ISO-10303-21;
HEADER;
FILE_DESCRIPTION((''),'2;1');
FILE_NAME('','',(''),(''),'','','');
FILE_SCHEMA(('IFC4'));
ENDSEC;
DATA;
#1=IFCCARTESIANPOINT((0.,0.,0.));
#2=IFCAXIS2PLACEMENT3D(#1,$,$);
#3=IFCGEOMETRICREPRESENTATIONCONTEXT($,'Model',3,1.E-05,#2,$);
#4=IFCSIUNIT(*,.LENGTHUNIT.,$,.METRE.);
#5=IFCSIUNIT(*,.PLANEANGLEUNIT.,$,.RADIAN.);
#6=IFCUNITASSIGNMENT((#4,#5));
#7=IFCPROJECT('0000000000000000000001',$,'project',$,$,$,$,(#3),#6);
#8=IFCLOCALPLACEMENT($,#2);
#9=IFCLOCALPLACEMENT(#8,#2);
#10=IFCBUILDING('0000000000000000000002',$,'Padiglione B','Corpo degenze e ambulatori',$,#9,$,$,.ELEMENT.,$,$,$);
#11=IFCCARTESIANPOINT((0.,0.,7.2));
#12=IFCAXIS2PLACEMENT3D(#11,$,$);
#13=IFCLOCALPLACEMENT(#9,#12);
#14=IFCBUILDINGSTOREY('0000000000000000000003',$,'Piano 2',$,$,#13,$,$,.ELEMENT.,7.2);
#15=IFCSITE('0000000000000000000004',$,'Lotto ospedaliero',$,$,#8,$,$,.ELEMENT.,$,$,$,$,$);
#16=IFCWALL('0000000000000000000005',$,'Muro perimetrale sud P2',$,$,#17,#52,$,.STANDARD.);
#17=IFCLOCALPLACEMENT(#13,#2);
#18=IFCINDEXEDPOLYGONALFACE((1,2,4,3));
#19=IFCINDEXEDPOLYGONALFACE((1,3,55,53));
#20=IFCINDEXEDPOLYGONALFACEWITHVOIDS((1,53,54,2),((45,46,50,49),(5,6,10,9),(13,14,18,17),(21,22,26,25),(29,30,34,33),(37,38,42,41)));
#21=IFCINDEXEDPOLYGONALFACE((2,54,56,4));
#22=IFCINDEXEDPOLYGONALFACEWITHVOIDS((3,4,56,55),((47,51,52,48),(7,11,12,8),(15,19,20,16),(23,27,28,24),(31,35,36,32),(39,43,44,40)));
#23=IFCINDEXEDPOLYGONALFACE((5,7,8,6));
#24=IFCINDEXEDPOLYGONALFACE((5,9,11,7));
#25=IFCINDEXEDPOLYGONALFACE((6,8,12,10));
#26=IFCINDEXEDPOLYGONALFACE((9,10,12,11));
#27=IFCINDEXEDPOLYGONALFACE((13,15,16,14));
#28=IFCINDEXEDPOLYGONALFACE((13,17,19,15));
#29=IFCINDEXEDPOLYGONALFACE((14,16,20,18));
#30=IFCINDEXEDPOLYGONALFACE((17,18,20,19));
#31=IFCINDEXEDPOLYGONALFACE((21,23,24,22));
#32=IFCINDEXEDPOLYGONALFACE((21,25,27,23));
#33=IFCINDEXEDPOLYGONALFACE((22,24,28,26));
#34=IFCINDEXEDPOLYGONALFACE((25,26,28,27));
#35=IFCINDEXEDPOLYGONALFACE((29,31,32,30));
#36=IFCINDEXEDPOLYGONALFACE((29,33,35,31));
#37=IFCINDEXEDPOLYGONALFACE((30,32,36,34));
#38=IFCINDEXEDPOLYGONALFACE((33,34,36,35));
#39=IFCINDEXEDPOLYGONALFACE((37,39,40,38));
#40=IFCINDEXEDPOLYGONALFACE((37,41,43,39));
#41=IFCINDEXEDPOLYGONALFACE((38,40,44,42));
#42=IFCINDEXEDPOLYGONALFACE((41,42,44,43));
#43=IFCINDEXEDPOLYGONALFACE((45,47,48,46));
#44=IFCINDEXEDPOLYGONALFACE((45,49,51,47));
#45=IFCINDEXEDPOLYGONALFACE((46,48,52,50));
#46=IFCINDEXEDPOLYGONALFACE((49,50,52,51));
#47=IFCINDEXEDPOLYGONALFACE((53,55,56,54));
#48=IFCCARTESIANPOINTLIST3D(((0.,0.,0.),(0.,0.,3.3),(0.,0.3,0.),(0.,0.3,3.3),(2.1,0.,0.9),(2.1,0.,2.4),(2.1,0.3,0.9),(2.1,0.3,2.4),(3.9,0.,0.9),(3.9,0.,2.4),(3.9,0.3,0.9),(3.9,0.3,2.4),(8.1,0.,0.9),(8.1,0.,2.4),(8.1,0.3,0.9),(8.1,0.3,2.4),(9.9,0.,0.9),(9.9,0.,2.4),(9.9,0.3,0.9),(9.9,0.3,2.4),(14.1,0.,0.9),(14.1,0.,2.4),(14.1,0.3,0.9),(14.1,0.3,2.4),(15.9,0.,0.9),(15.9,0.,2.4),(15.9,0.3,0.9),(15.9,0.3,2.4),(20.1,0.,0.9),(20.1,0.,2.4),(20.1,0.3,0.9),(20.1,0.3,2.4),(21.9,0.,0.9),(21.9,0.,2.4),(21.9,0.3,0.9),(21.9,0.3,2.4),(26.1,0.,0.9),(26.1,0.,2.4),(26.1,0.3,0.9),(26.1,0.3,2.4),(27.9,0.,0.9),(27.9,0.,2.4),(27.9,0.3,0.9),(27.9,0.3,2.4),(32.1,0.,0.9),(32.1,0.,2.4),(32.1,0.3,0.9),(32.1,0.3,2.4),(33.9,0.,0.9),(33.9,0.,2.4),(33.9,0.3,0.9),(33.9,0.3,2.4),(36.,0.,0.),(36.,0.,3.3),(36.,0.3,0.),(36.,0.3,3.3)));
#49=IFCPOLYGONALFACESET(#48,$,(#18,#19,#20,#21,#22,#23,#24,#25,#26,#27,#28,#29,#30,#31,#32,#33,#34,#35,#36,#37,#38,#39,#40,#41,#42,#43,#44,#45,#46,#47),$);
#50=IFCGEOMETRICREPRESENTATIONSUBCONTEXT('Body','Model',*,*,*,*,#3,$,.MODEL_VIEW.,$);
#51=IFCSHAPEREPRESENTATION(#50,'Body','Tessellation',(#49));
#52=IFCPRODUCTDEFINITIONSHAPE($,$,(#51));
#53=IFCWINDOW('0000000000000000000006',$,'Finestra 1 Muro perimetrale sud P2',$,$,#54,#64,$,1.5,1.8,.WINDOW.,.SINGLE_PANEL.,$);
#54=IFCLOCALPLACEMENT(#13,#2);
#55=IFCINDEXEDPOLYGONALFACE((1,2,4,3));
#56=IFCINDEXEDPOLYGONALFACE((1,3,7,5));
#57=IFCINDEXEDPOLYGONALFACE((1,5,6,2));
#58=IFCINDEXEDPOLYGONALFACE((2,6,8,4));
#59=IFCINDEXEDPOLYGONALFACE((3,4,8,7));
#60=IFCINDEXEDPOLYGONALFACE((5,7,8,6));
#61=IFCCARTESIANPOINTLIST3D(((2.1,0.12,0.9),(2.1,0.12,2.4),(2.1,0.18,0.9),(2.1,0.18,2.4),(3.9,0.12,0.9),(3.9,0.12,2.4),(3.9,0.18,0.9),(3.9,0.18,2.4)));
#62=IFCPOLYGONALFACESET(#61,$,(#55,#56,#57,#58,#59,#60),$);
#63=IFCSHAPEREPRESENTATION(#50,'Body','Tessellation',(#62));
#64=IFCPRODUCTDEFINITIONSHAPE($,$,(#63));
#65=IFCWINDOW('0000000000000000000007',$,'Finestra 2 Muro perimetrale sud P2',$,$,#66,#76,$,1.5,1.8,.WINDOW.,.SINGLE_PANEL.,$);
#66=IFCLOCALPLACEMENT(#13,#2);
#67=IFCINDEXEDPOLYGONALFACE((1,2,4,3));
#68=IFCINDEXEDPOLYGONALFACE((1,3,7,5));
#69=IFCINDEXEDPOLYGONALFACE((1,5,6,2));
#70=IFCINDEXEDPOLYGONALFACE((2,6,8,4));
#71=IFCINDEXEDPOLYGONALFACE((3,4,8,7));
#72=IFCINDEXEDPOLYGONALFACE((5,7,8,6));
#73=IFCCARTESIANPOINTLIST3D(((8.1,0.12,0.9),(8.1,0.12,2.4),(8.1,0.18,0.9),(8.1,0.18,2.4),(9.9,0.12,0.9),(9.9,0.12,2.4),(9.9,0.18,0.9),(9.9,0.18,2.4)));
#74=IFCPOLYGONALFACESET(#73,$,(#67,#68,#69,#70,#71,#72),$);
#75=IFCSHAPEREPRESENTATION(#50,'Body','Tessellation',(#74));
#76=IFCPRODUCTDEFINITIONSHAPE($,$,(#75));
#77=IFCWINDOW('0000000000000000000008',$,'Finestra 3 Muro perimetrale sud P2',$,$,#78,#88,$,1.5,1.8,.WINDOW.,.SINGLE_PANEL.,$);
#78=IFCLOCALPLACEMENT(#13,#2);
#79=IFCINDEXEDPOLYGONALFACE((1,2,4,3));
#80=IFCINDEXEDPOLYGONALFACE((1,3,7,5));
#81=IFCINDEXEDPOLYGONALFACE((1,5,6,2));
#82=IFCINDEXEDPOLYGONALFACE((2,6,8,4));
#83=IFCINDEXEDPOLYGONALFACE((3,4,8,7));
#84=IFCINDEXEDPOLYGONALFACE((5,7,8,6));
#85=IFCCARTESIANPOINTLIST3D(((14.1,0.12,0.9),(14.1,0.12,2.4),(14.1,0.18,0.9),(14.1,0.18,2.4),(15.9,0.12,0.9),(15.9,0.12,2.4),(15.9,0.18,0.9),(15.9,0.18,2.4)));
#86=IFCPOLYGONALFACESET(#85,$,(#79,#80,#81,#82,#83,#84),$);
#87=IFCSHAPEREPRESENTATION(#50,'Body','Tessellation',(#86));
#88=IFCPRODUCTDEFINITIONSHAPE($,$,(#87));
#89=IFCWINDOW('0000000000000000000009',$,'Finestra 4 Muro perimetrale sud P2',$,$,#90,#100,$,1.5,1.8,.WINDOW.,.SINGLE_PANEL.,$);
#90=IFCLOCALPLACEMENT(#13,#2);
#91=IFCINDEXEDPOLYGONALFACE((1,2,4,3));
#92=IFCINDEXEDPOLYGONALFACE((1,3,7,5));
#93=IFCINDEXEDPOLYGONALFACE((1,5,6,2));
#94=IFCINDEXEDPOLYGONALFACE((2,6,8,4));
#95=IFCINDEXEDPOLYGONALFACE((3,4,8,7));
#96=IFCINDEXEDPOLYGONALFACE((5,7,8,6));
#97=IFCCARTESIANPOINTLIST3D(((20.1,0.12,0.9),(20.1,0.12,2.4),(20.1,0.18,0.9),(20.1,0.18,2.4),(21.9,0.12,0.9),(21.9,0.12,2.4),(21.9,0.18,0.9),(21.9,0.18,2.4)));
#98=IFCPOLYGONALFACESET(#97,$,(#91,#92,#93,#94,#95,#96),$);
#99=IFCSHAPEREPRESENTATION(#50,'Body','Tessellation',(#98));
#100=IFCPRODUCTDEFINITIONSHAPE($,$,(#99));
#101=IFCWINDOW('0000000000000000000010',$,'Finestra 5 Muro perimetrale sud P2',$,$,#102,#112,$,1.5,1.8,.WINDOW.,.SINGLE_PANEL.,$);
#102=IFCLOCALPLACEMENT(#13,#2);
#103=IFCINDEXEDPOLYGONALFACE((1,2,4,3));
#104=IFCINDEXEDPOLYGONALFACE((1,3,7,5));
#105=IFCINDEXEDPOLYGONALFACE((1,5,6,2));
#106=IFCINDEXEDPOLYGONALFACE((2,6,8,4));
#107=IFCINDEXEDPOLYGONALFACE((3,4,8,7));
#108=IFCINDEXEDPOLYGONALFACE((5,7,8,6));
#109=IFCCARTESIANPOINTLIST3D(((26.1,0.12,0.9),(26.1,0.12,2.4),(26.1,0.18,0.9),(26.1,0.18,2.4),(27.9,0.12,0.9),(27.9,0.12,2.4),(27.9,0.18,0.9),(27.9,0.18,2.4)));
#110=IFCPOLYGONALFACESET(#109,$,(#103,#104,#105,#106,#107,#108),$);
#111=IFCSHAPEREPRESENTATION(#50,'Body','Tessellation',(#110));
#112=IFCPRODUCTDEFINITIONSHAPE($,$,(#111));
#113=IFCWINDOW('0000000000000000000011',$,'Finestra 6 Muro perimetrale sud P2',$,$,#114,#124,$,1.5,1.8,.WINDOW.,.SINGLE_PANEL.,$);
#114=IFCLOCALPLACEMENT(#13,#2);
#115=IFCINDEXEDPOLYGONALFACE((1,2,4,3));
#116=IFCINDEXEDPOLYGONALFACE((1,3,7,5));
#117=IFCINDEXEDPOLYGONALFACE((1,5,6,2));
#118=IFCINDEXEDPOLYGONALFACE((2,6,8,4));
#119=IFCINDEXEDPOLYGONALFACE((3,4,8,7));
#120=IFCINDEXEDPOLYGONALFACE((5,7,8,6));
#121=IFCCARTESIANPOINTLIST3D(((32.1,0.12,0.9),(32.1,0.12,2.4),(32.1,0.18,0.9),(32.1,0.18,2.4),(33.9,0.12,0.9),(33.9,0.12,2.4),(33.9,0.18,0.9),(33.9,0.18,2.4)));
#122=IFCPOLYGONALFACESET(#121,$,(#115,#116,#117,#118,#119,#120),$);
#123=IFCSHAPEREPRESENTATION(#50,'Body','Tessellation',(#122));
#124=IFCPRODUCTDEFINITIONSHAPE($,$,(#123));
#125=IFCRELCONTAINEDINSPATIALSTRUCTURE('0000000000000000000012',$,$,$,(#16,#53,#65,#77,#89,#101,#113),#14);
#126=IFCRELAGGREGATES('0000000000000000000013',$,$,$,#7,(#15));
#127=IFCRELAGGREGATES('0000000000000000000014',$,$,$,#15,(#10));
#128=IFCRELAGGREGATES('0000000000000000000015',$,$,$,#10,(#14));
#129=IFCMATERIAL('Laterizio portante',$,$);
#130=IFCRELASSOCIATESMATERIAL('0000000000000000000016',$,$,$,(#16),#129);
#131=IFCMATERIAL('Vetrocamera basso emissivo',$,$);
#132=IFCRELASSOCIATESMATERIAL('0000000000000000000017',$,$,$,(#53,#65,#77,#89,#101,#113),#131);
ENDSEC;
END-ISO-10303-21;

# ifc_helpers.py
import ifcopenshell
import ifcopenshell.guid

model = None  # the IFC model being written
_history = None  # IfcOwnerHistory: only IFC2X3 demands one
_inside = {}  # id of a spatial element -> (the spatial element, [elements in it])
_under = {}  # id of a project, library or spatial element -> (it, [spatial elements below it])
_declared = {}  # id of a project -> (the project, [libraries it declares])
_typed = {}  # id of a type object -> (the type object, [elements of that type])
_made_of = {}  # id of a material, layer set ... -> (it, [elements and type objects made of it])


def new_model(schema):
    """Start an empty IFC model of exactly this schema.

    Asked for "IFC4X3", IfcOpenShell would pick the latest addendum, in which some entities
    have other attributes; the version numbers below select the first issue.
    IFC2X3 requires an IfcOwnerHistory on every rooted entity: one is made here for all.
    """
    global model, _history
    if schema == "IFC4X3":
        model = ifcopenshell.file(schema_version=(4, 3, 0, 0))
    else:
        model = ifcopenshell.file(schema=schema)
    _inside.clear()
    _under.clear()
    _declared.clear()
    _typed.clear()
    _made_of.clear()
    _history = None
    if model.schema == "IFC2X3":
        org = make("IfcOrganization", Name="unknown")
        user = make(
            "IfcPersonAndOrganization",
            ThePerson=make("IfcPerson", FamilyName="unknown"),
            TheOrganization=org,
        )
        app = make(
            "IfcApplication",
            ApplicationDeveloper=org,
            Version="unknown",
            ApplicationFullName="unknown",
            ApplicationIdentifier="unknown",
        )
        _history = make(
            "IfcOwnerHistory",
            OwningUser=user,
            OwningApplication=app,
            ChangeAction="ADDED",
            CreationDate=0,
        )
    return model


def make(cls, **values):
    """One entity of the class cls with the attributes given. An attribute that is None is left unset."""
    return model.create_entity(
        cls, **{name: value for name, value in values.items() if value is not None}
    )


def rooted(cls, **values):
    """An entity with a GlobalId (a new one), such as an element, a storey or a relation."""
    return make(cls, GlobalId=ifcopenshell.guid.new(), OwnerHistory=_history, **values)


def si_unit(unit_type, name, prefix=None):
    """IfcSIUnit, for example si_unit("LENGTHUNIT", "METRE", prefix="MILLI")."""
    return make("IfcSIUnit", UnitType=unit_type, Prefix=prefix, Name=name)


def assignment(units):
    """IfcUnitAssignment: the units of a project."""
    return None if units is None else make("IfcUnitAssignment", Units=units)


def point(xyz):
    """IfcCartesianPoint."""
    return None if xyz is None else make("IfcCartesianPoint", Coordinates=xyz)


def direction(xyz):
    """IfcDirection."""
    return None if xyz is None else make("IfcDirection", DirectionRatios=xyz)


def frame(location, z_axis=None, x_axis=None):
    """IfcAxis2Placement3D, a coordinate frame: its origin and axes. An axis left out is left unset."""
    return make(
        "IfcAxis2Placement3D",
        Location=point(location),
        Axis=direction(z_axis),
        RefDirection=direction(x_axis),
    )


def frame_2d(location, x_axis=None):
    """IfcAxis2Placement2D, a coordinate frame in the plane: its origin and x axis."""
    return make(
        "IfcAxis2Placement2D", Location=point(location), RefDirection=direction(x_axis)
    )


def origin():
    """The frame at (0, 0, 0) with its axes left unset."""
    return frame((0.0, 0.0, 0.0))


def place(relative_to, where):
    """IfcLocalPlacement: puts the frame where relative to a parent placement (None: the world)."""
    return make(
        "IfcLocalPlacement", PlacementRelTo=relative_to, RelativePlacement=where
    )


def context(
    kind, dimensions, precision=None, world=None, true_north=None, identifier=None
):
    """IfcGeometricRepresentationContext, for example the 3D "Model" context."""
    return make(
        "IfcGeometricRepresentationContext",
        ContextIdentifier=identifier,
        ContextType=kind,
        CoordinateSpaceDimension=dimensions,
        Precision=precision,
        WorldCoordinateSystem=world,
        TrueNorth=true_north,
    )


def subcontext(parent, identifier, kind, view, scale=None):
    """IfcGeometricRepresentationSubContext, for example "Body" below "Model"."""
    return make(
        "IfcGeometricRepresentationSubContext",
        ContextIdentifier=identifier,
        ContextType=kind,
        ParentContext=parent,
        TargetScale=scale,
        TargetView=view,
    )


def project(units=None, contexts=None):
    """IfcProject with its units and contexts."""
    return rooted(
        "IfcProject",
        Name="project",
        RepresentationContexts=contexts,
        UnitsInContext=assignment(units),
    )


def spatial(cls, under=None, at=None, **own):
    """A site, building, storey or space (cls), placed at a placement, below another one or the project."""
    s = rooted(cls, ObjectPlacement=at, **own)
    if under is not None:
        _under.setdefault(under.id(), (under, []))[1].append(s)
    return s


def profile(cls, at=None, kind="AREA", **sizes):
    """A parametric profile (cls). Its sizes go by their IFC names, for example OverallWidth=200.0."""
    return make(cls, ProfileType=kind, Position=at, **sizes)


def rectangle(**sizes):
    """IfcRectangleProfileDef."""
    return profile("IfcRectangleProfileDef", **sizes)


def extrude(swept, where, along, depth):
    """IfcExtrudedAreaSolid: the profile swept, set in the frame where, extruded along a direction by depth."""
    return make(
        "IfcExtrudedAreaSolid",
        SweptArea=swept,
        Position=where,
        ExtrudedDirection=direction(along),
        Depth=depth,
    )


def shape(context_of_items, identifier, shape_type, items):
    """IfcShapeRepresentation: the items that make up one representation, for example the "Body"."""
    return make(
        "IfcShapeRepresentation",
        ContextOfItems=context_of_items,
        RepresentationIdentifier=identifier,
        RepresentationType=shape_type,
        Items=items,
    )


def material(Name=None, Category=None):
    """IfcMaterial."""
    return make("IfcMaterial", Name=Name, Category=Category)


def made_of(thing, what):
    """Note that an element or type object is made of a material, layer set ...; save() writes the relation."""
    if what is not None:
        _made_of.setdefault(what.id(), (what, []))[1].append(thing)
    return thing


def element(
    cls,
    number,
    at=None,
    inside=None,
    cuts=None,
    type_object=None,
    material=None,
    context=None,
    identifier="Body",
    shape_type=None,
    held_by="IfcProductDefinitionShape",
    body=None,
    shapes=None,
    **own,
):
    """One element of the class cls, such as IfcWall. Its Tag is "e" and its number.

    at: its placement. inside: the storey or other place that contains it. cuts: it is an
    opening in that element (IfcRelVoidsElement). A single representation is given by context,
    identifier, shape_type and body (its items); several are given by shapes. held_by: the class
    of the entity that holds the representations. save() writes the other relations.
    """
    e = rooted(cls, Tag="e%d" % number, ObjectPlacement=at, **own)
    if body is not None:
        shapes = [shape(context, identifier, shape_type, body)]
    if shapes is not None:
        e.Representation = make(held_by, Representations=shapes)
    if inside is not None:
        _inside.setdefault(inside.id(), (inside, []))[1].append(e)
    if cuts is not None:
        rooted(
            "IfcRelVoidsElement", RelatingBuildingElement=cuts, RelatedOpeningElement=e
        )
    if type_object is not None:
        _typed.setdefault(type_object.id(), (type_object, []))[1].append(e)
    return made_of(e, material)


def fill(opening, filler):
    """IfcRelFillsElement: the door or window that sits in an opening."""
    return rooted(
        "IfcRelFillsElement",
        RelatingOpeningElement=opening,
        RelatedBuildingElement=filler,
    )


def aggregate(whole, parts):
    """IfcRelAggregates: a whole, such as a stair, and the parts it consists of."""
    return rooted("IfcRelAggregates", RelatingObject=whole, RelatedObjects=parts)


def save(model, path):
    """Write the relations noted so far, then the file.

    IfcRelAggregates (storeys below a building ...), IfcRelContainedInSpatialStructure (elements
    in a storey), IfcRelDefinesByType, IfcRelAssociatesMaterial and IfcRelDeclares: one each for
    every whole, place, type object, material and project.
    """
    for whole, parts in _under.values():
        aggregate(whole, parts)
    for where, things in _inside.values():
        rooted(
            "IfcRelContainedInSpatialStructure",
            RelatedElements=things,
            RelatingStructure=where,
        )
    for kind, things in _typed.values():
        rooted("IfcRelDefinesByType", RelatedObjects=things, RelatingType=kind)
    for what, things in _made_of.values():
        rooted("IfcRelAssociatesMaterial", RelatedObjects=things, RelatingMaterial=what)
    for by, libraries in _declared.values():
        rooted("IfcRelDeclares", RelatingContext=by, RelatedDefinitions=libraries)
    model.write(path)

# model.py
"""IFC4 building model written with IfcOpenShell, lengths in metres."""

from ifc_helpers import new_model, si_unit, frame, frame_2d, origin, place, context, subcontext, project, spatial, rectangle, extrude, material, element, fill, save


model = new_model("IFC4")

# Units and contexts
model_context = context("Model", 3, precision=1e-05, world=origin())
body_context = subcontext(model_context, "Body", "Model", "MODEL_VIEW")
ifc_project = project(units=[si_unit("LENGTHUNIT", "METRE"), si_unit("PLANEANGLEUNIT", "RADIAN")], contexts=[model_context])

# Site, building, storey
site_placement = place(None, origin())
site = spatial("IfcSite", under=ifc_project, at=site_placement, Name="Lotto ospedaliero", CompositionType="ELEMENT")
building_placement = place(site_placement, origin())
building = spatial("IfcBuilding", under=site, at=building_placement, Name="Padiglione B", Description="Corpo degenze e ambulatori", CompositionType="ELEMENT")
storey_placement = place(building_placement, frame((0.0, 0.0, 7.2)))
storey = spatial("IfcBuildingStorey", under=building, at=storey_placement, Name="Piano 2", CompositionType="ELEMENT", Elevation=7.2)

# Wall, openings, windows
ifc_material_1 = material(Name="Laterizio portante")
wall_1_placement = place(storey_placement, origin())
wall_1 = element("IfcWall", 1, at=wall_1_placement, inside=storey, material=ifc_material_1, Name="Muro perimetrale sud P2", PredefinedType="STANDARD", context=body_context, shape_type="SweptSolid", body=[
    extrude(rectangle(XDim=36.0, YDim=0.3, at=frame_2d((18.0, 0.15))), origin(), (0.0, 0.0, 1.0), 3.3),
])
opening_1_placement = place(wall_1_placement, frame((2.1, -0.1, 0.9)))
opening_1 = element("IfcOpeningElement", 2, at=opening_1_placement, cuts=wall_1, PredefinedType="OPENING", context=body_context, shape_type="SweptSolid", body=[
    extrude(rectangle(XDim=1.8, YDim=0.5, at=frame_2d((0.9, 0.25))), origin(), (0.0, 0.0, 1.0), 1.5),
])
opening_2_placement = place(wall_1_placement, frame((8.1, -0.1, 0.9)))
opening_2 = element("IfcOpeningElement", 3, at=opening_2_placement, cuts=wall_1, PredefinedType="OPENING", context=body_context, shape_type="SweptSolid", body=[
    extrude(rectangle(XDim=1.8, YDim=0.5, at=frame_2d((0.9, 0.25))), origin(), (0.0, 0.0, 1.0), 1.5),
])
opening_3_placement = place(wall_1_placement, frame((14.1, -0.1, 0.9)))
opening_3 = element("IfcOpeningElement", 4, at=opening_3_placement, cuts=wall_1, PredefinedType="OPENING", context=body_context, shape_type="SweptSolid", body=[
    extrude(rectangle(XDim=1.8, YDim=0.5, at=frame_2d((0.9, 0.25))), origin(), (0.0, 0.0, 1.0), 1.5),
])
opening_4_placement = place(wall_1_placement, frame((20.1, -0.1, 0.9)))
opening_4 = element("IfcOpeningElement", 5, at=opening_4_placement, cuts=wall_1, PredefinedType="OPENING", context=body_context, shape_type="SweptSolid", body=[
    extrude(rectangle(XDim=1.8, YDim=0.5, at=frame_2d((0.9, 0.25))), origin(), (0.0, 0.0, 1.0), 1.5),
])
opening_5_placement = place(wall_1_placement, frame((26.1, -0.1, 0.9)))
opening_5 = element("IfcOpeningElement", 6, at=opening_5_placement, cuts=wall_1, PredefinedType="OPENING", context=body_context, shape_type="SweptSolid", body=[
    extrude(rectangle(XDim=1.8, YDim=0.5, at=frame_2d((0.9, 0.25))), origin(), (0.0, 0.0, 1.0), 1.5),
])
opening_6_placement = place(wall_1_placement, frame((32.1, -0.1, 0.9)))
opening_6 = element("IfcOpeningElement", 7, at=opening_6_placement, cuts=wall_1, PredefinedType="OPENING", context=body_context, shape_type="SweptSolid", body=[
    extrude(rectangle(XDim=1.8, YDim=0.5, at=frame_2d((0.9, 0.25))), origin(), (0.0, 0.0, 1.0), 1.5),
])
ifc_material_2 = material(Name="Vetrocamera basso emissivo")
window_1_placement = place(wall_1_placement, frame((2.1, 0.12, 0.9)))
window_1 = element("IfcWindow", 8, at=window_1_placement, inside=storey, material=ifc_material_2, Name="Finestra 1 Muro perimetrale sud P2", OverallHeight=1.5, OverallWidth=1.8, PartitioningType="SINGLE_PANEL", PredefinedType="WINDOW", context=body_context, shape_type="SweptSolid", body=[
    extrude(rectangle(XDim=1.8, YDim=0.06, at=frame_2d((0.9, 0.03))), origin(), (0.0, 0.0, 1.0), 1.5),
])
fill(opening_1, window_1)
window_2_placement = place(wall_1_placement, frame((8.1, 0.12, 0.9)))
window_2 = element("IfcWindow", 9, at=window_2_placement, inside=storey, material=ifc_material_2, Name="Finestra 2 Muro perimetrale sud P2", OverallHeight=1.5, OverallWidth=1.8, PartitioningType="SINGLE_PANEL", PredefinedType="WINDOW", context=body_context, shape_type="SweptSolid", body=[
    extrude(rectangle(XDim=1.8, YDim=0.06, at=frame_2d((0.9, 0.03))), origin(), (0.0, 0.0, 1.0), 1.5),
])
fill(opening_2, window_2)
window_3_placement = place(wall_1_placement, frame((14.1, 0.12, 0.9)))
window_3 = element("IfcWindow", 10, at=window_3_placement, inside=storey, material=ifc_material_2, Name="Finestra 3 Muro perimetrale sud P2", OverallHeight=1.5, OverallWidth=1.8, PartitioningType="SINGLE_PANEL", PredefinedType="WINDOW", context=body_context, shape_type="SweptSolid", body=[
    extrude(rectangle(XDim=1.8, YDim=0.06, at=frame_2d((0.9, 0.03))), origin(), (0.0, 0.0, 1.0), 1.5),
])
fill(opening_3, window_3)
window_4_placement = place(wall_1_placement, frame((20.1, 0.12, 0.9)))
window_4 = element("IfcWindow", 11, at=window_4_placement, inside=storey, material=ifc_material_2, Name="Finestra 4 Muro perimetrale sud P2", OverallHeight=1.5, OverallWidth=1.8, PartitioningType="SINGLE_PANEL", PredefinedType="WINDOW", context=body_context, shape_type="SweptSolid", body=[
    extrude(rectangle(XDim=1.8, YDim=0.06, at=frame_2d((0.9, 0.03))), origin(), (0.0, 0.0, 1.0), 1.5),
])
fill(opening_4, window_4)
window_5_placement = place(wall_1_placement, frame((26.1, 0.12, 0.9)))
window_5 = element("IfcWindow", 12, at=window_5_placement, inside=storey, material=ifc_material_2, Name="Finestra 5 Muro perimetrale sud P2", OverallHeight=1.5, OverallWidth=1.8, PartitioningType="SINGLE_PANEL", PredefinedType="WINDOW", context=body_context, shape_type="SweptSolid", body=[
    extrude(rectangle(XDim=1.8, YDim=0.06, at=frame_2d((0.9, 0.03))), origin(), (0.0, 0.0, 1.0), 1.5),
])
fill(opening_5, window_5)
window_6_placement = place(wall_1_placement, frame((32.1, 0.12, 0.9)))
window_6 = element("IfcWindow", 13, at=window_6_placement, inside=storey, material=ifc_material_2, Name="Finestra 6 Muro perimetrale sud P2", OverallHeight=1.5, OverallWidth=1.8, PartitioningType="SINGLE_PANEL", PredefinedType="WINDOW", context=body_context, shape_type="SweptSolid", body=[
    extrude(rectangle(XDim=1.8, YDim=0.06, at=frame_2d((0.9, 0.03))), origin(), (0.0, 0.0, 1.0), 1.5),
])
fill(opening_6, window_6)

save(model, "model.ifc")
